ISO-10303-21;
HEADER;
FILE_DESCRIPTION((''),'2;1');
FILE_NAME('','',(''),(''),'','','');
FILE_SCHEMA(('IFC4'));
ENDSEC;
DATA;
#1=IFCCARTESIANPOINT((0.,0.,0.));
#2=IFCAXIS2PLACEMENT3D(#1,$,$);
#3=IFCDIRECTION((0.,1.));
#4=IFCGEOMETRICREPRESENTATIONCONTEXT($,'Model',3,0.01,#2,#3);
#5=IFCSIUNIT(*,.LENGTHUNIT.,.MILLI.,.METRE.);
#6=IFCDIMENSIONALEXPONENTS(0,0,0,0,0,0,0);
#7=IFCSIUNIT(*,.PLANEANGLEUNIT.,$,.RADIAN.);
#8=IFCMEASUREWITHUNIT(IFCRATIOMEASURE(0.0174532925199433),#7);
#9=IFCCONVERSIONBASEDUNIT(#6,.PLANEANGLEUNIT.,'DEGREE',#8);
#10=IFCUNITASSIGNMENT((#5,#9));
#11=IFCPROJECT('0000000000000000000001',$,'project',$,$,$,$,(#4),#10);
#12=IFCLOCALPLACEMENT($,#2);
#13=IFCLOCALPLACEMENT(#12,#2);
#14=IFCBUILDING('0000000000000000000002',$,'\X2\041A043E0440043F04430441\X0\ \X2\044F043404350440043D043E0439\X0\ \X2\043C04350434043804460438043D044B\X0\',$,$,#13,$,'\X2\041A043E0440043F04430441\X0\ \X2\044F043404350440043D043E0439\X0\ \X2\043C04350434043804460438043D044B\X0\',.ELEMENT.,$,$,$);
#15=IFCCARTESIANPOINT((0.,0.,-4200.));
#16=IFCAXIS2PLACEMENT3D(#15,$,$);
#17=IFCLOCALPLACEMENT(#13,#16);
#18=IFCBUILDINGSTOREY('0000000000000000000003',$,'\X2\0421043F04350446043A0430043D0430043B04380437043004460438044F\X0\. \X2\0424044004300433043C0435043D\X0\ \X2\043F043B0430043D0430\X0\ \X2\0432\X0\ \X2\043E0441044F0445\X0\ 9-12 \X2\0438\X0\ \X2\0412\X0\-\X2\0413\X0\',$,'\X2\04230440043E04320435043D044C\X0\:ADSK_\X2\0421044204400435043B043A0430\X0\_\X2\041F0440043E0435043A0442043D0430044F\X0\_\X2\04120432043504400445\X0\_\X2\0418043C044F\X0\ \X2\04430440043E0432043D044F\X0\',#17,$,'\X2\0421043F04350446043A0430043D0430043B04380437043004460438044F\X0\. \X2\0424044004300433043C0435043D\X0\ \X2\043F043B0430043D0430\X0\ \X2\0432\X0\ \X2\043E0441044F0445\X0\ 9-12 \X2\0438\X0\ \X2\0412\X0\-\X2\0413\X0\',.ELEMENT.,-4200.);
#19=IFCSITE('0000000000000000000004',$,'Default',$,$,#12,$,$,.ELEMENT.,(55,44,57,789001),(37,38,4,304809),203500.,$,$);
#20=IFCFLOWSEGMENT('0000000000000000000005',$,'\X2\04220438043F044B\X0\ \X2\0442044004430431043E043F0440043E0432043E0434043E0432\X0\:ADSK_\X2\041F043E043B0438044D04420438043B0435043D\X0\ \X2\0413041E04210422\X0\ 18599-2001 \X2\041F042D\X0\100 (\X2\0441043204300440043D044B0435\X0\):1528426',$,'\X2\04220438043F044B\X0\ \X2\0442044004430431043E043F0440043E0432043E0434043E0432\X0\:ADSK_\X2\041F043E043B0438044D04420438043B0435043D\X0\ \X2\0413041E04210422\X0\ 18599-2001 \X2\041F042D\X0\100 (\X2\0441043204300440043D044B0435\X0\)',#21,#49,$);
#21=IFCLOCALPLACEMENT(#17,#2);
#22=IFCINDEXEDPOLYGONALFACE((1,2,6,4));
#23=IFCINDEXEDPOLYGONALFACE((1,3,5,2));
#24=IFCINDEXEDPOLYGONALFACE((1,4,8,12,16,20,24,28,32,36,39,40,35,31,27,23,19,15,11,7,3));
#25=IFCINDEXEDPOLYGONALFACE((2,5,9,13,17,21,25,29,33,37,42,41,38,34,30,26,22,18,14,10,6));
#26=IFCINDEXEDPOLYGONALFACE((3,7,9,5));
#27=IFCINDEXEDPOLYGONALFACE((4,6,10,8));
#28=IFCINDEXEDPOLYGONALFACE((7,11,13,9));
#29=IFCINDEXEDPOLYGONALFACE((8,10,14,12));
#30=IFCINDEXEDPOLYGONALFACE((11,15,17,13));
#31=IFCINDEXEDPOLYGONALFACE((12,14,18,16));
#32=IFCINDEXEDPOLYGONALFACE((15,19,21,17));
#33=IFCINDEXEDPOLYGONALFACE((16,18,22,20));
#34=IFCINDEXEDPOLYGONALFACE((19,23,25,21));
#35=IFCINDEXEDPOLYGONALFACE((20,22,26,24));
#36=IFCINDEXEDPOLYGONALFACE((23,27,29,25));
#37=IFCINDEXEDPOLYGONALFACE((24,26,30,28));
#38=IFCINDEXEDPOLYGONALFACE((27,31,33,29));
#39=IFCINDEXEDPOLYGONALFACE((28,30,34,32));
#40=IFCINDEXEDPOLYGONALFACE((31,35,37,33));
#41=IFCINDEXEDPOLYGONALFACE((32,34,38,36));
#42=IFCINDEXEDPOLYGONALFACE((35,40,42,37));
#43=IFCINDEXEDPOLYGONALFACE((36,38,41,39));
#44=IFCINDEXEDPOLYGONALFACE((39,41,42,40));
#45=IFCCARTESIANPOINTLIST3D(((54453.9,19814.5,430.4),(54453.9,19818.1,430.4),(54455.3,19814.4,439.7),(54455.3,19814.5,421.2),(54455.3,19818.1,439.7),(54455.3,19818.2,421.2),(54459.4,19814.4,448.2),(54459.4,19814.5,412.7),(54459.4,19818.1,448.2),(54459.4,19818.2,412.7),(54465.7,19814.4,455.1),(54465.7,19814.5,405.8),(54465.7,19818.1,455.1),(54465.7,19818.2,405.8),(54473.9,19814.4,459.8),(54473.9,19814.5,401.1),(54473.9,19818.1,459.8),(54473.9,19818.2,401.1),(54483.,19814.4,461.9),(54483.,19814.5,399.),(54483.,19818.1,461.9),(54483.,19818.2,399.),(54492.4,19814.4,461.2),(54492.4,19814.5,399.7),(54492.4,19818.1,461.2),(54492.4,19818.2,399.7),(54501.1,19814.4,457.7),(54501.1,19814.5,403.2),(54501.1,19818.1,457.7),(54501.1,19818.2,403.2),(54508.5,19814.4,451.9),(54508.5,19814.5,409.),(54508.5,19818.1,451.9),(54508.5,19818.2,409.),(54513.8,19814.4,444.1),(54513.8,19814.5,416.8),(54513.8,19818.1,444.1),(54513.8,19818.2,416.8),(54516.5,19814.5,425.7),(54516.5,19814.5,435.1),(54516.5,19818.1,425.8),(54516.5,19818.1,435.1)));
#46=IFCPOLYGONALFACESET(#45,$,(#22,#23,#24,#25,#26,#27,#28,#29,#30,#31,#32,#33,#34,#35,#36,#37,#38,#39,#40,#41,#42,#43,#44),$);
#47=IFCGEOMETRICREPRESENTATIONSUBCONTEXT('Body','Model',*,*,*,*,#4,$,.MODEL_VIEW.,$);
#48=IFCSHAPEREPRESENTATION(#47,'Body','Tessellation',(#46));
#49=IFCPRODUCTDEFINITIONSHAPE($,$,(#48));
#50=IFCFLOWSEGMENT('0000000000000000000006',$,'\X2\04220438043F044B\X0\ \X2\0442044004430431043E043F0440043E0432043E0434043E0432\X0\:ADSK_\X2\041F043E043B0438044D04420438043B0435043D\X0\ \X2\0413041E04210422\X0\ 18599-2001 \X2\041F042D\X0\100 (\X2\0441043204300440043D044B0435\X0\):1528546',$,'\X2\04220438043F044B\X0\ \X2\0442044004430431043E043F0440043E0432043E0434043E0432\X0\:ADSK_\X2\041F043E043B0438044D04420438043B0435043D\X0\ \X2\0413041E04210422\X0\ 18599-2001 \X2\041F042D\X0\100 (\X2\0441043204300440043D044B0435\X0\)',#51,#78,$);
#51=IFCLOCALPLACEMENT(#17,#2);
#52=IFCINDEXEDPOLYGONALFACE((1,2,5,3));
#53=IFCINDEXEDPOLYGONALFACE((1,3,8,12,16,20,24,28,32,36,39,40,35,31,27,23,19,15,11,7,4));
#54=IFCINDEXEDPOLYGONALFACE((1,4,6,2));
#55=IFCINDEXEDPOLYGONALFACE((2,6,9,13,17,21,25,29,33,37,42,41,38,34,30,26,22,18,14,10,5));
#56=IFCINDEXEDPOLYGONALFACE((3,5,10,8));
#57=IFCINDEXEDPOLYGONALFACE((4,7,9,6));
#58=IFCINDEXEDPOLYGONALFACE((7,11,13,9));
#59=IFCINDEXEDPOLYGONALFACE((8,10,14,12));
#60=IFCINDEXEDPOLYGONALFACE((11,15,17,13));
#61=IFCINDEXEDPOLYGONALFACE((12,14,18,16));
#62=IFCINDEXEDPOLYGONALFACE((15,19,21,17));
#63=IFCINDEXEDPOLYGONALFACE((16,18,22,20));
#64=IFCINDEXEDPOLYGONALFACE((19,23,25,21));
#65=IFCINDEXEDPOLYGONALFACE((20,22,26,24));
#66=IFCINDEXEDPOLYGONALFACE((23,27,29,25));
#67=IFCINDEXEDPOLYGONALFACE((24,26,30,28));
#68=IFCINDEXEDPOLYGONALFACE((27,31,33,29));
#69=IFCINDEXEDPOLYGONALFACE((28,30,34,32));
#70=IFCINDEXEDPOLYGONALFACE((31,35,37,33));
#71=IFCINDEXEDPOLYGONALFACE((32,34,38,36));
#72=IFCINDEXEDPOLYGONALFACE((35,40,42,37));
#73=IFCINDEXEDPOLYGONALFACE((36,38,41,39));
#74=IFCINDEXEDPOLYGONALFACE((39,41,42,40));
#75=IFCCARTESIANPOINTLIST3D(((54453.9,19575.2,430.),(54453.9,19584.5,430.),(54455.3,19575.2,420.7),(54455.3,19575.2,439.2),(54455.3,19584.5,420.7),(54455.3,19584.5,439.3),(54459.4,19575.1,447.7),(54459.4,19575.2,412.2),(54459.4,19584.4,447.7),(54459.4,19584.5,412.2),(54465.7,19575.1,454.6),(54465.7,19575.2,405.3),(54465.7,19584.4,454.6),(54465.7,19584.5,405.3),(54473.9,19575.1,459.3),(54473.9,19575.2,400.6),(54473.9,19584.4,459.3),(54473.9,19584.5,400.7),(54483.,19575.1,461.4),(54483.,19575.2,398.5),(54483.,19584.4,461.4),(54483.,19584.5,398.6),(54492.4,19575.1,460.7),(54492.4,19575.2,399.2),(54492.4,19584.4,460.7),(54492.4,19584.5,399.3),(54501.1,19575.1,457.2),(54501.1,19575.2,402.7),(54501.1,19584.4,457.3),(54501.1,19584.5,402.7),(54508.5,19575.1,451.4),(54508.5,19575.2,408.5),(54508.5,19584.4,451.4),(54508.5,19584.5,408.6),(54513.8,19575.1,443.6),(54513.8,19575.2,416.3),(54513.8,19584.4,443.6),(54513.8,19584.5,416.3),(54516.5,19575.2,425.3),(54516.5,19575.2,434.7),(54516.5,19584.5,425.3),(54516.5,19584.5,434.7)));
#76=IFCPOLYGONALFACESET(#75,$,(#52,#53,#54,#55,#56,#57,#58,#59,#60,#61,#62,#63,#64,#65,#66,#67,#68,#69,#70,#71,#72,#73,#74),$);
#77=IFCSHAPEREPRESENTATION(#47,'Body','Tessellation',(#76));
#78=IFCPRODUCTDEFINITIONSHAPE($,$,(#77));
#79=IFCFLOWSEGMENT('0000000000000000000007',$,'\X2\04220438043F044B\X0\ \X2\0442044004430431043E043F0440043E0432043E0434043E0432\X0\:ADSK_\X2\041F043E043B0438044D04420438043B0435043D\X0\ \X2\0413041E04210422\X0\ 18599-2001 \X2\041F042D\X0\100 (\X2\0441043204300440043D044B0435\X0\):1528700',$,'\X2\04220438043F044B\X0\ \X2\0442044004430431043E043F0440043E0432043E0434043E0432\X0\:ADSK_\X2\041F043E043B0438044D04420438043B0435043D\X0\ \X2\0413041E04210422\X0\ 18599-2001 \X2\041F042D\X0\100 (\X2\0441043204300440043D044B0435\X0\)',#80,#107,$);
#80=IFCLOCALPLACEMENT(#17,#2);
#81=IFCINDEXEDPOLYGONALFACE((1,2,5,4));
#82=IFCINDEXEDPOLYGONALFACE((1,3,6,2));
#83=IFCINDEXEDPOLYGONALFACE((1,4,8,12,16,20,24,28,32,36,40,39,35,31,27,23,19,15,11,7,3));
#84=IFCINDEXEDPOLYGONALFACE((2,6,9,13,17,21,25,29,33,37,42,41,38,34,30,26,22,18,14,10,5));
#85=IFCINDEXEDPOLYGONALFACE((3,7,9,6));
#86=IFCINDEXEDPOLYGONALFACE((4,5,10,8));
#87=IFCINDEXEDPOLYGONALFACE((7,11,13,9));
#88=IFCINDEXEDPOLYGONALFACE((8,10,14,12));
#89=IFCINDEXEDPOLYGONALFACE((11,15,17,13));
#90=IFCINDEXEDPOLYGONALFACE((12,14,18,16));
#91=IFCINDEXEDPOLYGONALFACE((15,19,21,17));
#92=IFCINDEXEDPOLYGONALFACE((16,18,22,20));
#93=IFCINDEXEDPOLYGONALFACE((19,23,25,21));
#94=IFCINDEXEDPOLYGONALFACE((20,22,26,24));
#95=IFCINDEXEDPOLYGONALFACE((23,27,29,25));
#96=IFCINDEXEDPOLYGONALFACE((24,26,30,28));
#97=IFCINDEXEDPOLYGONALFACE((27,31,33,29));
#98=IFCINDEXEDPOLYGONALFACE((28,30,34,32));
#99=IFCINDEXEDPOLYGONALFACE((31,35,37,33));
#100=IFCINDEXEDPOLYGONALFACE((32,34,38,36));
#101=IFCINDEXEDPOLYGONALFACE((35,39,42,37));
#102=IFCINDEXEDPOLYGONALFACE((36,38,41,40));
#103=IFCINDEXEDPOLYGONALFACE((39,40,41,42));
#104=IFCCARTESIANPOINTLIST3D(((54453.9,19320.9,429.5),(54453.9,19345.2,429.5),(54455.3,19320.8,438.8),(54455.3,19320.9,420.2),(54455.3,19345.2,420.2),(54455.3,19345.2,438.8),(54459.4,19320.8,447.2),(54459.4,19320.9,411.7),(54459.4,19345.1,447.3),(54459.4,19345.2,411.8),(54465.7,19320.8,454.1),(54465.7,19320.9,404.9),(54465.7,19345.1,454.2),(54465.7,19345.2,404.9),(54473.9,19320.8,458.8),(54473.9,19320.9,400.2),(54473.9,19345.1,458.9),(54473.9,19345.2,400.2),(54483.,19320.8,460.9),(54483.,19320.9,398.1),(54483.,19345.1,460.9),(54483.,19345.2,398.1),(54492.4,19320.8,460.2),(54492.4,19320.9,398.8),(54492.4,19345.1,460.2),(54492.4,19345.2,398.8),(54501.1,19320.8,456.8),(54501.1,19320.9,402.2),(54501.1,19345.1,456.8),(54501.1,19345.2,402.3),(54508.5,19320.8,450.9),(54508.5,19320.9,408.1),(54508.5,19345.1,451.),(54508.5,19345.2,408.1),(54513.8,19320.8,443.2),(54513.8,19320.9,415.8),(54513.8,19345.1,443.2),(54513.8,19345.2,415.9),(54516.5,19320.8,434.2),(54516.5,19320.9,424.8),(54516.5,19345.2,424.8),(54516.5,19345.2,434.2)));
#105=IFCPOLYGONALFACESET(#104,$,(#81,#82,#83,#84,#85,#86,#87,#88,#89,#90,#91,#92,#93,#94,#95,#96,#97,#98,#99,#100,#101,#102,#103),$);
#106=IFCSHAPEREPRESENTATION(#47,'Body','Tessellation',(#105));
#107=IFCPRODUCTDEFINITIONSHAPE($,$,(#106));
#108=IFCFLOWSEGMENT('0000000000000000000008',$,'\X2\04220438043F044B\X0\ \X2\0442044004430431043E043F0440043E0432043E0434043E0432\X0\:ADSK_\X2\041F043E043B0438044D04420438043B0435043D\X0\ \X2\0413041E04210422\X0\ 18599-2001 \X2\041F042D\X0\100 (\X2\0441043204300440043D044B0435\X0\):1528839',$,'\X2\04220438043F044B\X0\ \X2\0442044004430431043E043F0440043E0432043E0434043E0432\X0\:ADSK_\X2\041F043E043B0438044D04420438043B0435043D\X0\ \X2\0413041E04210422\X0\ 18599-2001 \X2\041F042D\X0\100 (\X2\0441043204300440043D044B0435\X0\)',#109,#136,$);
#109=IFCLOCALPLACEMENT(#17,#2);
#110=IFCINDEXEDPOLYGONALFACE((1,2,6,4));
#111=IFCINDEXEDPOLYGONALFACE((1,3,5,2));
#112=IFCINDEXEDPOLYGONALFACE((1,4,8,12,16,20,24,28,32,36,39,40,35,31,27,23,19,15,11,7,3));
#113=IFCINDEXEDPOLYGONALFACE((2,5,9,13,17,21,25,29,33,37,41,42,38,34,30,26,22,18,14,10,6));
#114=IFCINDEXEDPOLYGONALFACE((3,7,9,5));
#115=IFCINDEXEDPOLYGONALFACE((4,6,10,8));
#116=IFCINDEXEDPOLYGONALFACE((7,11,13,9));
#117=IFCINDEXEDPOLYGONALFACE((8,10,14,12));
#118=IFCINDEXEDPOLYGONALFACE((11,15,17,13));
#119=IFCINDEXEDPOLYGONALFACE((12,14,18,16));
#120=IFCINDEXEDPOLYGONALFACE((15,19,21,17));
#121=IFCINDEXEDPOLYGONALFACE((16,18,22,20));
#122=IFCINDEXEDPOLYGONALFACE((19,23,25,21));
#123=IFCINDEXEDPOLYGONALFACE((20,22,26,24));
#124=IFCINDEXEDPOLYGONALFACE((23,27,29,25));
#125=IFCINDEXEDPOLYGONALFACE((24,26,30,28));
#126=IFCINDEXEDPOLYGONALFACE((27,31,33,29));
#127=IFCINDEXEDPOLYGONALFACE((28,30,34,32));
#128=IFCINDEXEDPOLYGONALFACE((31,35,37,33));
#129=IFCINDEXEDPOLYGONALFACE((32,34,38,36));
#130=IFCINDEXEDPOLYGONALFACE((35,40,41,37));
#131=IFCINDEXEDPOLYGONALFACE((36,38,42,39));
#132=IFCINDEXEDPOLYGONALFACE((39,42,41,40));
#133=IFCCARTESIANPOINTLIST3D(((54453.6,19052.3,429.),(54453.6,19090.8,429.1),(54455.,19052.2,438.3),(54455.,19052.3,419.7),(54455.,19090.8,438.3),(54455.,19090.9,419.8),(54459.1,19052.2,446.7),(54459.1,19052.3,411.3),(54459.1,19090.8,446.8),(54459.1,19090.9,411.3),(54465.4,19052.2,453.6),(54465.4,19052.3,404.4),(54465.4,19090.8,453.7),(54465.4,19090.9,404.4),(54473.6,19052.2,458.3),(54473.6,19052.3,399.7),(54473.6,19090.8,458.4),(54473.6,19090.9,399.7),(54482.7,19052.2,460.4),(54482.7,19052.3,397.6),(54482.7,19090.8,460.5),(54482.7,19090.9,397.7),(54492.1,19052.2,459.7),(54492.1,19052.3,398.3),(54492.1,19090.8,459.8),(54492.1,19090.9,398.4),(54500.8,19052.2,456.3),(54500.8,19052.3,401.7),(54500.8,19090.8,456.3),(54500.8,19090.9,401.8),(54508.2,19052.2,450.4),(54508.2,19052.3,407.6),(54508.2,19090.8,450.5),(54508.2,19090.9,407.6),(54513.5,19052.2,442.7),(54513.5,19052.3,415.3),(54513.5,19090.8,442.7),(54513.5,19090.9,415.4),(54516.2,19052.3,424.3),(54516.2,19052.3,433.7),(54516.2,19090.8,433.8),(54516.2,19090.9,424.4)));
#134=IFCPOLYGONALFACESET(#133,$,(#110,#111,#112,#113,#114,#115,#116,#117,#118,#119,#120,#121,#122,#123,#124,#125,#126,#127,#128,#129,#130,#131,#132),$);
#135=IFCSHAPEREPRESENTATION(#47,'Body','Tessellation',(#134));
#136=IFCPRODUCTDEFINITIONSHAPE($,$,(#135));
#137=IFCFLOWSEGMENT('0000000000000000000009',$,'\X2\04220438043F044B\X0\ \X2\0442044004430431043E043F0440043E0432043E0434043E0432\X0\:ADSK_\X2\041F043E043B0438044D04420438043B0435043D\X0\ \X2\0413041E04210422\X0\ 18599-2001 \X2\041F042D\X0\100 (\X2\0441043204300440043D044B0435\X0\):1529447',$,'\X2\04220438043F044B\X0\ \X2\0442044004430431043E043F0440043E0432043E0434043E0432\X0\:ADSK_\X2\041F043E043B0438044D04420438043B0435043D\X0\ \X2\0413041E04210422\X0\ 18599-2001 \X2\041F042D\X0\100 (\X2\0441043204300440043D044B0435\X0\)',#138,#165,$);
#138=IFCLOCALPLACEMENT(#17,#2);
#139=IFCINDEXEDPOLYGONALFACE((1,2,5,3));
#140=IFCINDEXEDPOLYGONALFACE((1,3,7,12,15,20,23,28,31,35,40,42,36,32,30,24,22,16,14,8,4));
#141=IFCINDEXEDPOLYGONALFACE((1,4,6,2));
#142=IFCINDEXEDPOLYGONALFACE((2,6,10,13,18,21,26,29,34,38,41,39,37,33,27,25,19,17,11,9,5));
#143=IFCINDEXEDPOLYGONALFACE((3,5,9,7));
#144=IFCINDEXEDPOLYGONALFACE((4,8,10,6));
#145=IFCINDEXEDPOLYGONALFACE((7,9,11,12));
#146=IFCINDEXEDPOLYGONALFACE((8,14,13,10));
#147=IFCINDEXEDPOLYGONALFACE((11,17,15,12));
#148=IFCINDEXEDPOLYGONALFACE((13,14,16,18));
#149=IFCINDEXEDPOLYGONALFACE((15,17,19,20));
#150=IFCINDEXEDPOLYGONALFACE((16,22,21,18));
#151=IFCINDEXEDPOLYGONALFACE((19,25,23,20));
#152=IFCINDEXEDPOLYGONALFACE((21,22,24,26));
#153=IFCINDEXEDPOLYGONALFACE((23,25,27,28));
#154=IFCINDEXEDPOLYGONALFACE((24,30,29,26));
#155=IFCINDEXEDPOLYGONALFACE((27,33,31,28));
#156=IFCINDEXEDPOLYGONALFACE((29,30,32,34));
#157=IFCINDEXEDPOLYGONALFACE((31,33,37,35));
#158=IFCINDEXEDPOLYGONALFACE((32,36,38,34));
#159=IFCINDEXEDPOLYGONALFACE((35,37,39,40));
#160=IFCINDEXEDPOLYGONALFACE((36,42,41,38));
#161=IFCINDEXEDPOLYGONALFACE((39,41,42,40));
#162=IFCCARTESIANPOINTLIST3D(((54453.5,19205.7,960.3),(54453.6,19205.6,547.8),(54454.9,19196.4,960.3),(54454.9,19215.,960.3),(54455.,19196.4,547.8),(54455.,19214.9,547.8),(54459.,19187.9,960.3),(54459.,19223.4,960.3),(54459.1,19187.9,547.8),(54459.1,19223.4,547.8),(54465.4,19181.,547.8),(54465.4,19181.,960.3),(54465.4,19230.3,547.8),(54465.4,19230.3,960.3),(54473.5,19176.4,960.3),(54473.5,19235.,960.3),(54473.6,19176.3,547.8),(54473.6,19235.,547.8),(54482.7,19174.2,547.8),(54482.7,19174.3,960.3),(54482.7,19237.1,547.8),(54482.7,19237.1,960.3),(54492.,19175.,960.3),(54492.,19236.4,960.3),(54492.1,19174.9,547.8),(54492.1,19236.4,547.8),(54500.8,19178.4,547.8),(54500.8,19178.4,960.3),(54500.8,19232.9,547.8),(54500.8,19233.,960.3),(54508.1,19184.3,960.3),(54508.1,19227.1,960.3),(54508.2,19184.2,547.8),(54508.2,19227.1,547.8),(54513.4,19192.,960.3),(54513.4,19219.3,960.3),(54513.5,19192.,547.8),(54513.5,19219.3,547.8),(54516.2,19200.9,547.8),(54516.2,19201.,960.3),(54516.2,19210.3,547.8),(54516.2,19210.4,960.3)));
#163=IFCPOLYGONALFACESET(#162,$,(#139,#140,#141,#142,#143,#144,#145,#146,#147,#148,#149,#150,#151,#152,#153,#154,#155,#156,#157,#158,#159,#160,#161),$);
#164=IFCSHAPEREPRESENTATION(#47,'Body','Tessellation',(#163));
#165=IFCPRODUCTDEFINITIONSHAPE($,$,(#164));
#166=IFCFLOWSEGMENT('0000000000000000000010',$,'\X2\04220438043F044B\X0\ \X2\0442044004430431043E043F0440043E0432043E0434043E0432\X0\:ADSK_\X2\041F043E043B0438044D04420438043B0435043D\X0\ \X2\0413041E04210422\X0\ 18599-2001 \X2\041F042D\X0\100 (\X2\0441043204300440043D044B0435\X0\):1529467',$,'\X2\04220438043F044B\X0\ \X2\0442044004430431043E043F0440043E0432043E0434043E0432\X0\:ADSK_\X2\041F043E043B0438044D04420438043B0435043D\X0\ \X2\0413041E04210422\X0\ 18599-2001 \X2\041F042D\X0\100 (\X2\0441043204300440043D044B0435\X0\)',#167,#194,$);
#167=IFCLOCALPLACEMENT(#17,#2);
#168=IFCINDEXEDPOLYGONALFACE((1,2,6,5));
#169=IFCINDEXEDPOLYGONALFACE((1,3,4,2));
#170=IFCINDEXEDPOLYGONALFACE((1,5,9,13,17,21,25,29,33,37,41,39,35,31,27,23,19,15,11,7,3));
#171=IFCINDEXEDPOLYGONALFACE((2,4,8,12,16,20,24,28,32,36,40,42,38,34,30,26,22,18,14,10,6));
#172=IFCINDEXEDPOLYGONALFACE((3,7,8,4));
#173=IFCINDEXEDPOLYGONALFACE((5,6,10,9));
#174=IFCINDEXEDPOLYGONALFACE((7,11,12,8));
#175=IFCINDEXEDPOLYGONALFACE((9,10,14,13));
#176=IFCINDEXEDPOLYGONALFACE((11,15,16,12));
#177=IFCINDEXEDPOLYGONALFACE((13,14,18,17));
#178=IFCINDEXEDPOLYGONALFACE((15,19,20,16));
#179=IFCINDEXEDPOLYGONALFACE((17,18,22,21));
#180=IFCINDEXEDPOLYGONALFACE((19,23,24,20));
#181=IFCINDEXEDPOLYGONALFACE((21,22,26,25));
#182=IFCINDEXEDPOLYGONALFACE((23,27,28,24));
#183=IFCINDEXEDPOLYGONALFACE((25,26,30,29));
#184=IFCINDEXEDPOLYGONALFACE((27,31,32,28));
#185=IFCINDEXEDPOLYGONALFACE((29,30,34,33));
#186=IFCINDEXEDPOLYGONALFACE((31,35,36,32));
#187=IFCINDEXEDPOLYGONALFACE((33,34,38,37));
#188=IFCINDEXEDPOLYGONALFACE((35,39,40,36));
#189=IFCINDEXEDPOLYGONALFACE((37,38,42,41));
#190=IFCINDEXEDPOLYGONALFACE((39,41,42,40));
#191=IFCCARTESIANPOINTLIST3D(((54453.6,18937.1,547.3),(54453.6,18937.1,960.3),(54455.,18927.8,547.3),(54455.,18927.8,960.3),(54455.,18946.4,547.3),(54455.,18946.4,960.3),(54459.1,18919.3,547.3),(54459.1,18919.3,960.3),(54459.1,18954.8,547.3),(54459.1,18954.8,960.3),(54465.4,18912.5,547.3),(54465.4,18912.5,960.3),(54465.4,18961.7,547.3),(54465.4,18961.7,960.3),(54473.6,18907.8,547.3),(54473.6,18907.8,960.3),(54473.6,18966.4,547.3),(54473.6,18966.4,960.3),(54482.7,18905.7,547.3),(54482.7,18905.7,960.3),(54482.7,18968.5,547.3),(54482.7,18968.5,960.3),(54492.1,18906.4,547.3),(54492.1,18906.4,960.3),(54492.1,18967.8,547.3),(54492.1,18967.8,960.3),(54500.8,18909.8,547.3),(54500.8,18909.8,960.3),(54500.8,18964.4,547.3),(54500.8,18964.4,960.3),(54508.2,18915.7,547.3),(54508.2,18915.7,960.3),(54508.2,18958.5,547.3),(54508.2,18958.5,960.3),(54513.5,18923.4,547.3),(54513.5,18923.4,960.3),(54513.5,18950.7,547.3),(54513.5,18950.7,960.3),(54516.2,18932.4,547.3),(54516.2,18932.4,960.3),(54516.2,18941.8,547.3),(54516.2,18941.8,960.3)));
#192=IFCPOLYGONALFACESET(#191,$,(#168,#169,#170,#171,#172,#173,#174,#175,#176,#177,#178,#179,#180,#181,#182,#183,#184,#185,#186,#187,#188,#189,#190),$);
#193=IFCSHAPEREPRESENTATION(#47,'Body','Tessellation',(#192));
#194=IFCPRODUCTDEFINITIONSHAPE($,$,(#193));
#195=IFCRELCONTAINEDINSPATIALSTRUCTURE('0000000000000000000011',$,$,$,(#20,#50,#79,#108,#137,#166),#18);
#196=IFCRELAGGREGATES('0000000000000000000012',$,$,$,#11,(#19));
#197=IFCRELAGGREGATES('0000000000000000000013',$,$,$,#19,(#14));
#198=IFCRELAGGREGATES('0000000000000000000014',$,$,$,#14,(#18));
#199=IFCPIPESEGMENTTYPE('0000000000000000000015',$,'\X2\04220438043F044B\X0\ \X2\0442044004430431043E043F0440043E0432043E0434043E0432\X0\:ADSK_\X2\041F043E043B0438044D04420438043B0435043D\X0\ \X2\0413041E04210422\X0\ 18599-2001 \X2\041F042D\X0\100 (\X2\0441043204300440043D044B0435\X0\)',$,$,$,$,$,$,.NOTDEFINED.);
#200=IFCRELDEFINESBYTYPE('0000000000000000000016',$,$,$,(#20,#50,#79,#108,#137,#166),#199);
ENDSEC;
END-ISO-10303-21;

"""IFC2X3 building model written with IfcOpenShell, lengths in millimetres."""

from ifc_helpers import new_model, entity, si_unit, converted_unit, direction, frame, origin, origin_2d_with_axis, place, context, subcontext, project, spatial, circle, extrude, type_object, element, save


model = new_model("IFC2X3")

# Units and contexts
model_context = context("Model", 3, precision=0.01, world=origin(), true_north=direction((0.0, 1.0)))
body_context = subcontext(model_context, "Body", "Model", "MODEL_VIEW")
ifc_project = project(units=[si_unit("LENGTHUNIT", "METRE", prefix="MILLI"), converted_unit("PLANEANGLEUNIT", "DEGREE", entity("IfcRatioMeasure", 0.0174532925199433), si_unit("PLANEANGLEUNIT", "RADIAN"), dimensions=[0, 0, 0, 0, 0, 0, 0])], contexts=[model_context])

# Site, building, storey
site_placement = place(None, origin())
site = spatial("IfcSite", under=ifc_project, at=site_placement, Name="Default", CompositionType="ELEMENT", RefLatitude=(55, 44, 57, 789001), RefLongitude=(37, 38, 4, 304809), RefElevation=203500.0)
building_placement = place(site_placement, origin())
building = spatial("IfcBuilding", under=site, at=building_placement, Name="Корпус ядерной медицины", LongName="Корпус ядерной медицины", CompositionType="ELEMENT")
storey_placement = place(building_placement, frame((0.0, 0.0, -4200.0)))
storey = spatial("IfcBuildingStorey", under=building, at=storey_placement, Name="Спецканализация. Фрагмен плана в осях 9-12 и В-Г", ObjectType="Уровень:ADSK_Стрелка_Проектная_Вверх_Имя уровня", LongName="Спецканализация. Фрагмен плана в осях 9-12 и В-Г", CompositionType="ELEMENT", Elevation=-4200.0)

# Flow segments
pipe_segment_type = type_object("IfcPipeSegmentType", Name="Типы трубопроводов:ADSK_Полиэтилен ГОСТ 18599-2001 ПЭ100 (сварные)", PredefinedType="NOTDEFINED")
flow_segment_1_placement = place(storey_placement, frame((54452.3, 19814.4, 397.3)))
element("IfcFlowSegment", 1, at=flow_segment_1_placement, inside=storey, type_object=pipe_segment_type, Name="Типы трубопроводов:ADSK_Полиэтилен ГОСТ 18599-2001 ПЭ100 (сварные):1528426", ObjectType="Типы трубопроводов:ADSK_Полиэтилен ГОСТ 18599-2001 ПЭ100 (сварные)", context=body_context, shape_type="SweptSolid", body=[
    extrude(circle(Radius=31.5, at=origin_2d_with_axis()), frame((33.1, 0.1, 33.1), z_axis=(0.0, 0.999998, 0.002), x_axis=(-1.0, 0.0, 0.0)), (0.0, 0.0, 1.0), 3.7),
])
flow_segment_2_placement = place(storey_placement, frame((54452.3, 19575.1, 396.9)))
element("IfcFlowSegment", 2, at=flow_segment_2_placement, inside=storey, type_object=pipe_segment_type, Name="Типы трубопроводов:ADSK_Полиэтилен ГОСТ 18599-2001 ПЭ100 (сварные):1528546", ObjectType="Типы трубопроводов:ADSK_Полиэтилен ГОСТ 18599-2001 ПЭ100 (сварные)", context=body_context, shape_type="SweptSolid", body=[
    extrude(circle(Radius=31.5, at=origin_2d_with_axis()), frame((33.1, 0.1, 33.1), z_axis=(0.0, 0.999998, 0.001851), x_axis=(-1.0, 0.0, 0.0)), (0.0, 0.0, 1.0), 9.3),
])
flow_segment_3_placement = place(storey_placement, frame((54452.3, 19320.8, 396.4)))
element("IfcFlowSegment", 3, at=flow_segment_3_placement, inside=storey, type_object=pipe_segment_type, Name="Типы трубопроводов:ADSK_Полиэтилен ГОСТ 18599-2001 ПЭ100 (сварные):1528700", ObjectType="Типы трубопроводов:ADSK_Полиэтилен ГОСТ 18599-2001 ПЭ100 (сварные)", context=body_context, shape_type="SweptSolid", body=[
    extrude(circle(Radius=31.5, at=origin_2d_with_axis()), frame((33.1, 0.1, 33.1), z_axis=(0.0, 0.999998, 0.001801), x_axis=(-1.0, 0.0, 0.0)), (0.0, 0.0, 1.0), 24.3),
])
flow_segment_4_placement = place(storey_placement, frame((54452.0, 19052.2, 395.9)))
element("IfcFlowSegment", 4, at=flow_segment_4_placement, inside=storey, type_object=pipe_segment_type, Name="Типы трубопроводов:ADSK_Полиэтилен ГОСТ 18599-2001 ПЭ100 (сварные):1528839", ObjectType="Типы трубопроводов:ADSK_Полиэтилен ГОСТ 18599-2001 ПЭ100 (сварные)", context=body_context, shape_type="SweptSolid", body=[
    extrude(circle(Radius=31.5, at=origin_2d_with_axis()), frame((33.1, 0.1, 33.1), z_axis=(0.000013, 0.999999, 0.001623), x_axis=(-1.0, 0.000013, 0.0)), (0.0, 0.0, 1.0), 38.6),
])
flow_segment_5_placement = place(storey_placement, frame((54451.9, 19172.5, 547.8)))
element("IfcFlowSegment", 5, at=flow_segment_5_placement, inside=storey, type_object=pipe_segment_type, Name="Типы трубопроводов:ADSK_Полиэтилен ГОСТ 18599-2001 ПЭ100 (сварные):1529447", ObjectType="Типы трубопроводов:ADSK_Полиэтилен ГОСТ 18599-2001 ПЭ100 (сварные)", context=body_context, shape_type="SweptSolid", body=[
    extrude(circle(Radius=31.5, at=origin_2d_with_axis()), frame((33.1, 33.1, 0.0), z_axis=(-0.000137, 0.000088, 1.0), x_axis=(-1.0, 0.0, -0.000137)), (0.0, 0.0, 1.0), 412.5),
])
flow_segment_6_placement = place(storey_placement, frame((54452.0, 18904.0, 547.3)))
element("IfcFlowSegment", 6, at=flow_segment_6_placement, inside=storey, type_object=pipe_segment_type, Name="Типы трубопроводов:ADSK_Полиэтилен ГОСТ 18599-2001 ПЭ100 (сварные):1529467", ObjectType="Типы трубопроводов:ADSK_Полиэтилен ГОСТ 18599-2001 ПЭ100 (сварные)", context=body_context, shape_type="SweptSolid", body=[
    extrude(circle(Radius=31.5, at=origin_2d_with_axis()), frame((33.1, 33.1, 0.0), z_axis=(-0.000001, 0.0, 1.0), x_axis=(-1.0, 0.0, -0.000001)), (0.0, 0.0, 1.0), 413.0),
])

save(model, "model.ifc")
